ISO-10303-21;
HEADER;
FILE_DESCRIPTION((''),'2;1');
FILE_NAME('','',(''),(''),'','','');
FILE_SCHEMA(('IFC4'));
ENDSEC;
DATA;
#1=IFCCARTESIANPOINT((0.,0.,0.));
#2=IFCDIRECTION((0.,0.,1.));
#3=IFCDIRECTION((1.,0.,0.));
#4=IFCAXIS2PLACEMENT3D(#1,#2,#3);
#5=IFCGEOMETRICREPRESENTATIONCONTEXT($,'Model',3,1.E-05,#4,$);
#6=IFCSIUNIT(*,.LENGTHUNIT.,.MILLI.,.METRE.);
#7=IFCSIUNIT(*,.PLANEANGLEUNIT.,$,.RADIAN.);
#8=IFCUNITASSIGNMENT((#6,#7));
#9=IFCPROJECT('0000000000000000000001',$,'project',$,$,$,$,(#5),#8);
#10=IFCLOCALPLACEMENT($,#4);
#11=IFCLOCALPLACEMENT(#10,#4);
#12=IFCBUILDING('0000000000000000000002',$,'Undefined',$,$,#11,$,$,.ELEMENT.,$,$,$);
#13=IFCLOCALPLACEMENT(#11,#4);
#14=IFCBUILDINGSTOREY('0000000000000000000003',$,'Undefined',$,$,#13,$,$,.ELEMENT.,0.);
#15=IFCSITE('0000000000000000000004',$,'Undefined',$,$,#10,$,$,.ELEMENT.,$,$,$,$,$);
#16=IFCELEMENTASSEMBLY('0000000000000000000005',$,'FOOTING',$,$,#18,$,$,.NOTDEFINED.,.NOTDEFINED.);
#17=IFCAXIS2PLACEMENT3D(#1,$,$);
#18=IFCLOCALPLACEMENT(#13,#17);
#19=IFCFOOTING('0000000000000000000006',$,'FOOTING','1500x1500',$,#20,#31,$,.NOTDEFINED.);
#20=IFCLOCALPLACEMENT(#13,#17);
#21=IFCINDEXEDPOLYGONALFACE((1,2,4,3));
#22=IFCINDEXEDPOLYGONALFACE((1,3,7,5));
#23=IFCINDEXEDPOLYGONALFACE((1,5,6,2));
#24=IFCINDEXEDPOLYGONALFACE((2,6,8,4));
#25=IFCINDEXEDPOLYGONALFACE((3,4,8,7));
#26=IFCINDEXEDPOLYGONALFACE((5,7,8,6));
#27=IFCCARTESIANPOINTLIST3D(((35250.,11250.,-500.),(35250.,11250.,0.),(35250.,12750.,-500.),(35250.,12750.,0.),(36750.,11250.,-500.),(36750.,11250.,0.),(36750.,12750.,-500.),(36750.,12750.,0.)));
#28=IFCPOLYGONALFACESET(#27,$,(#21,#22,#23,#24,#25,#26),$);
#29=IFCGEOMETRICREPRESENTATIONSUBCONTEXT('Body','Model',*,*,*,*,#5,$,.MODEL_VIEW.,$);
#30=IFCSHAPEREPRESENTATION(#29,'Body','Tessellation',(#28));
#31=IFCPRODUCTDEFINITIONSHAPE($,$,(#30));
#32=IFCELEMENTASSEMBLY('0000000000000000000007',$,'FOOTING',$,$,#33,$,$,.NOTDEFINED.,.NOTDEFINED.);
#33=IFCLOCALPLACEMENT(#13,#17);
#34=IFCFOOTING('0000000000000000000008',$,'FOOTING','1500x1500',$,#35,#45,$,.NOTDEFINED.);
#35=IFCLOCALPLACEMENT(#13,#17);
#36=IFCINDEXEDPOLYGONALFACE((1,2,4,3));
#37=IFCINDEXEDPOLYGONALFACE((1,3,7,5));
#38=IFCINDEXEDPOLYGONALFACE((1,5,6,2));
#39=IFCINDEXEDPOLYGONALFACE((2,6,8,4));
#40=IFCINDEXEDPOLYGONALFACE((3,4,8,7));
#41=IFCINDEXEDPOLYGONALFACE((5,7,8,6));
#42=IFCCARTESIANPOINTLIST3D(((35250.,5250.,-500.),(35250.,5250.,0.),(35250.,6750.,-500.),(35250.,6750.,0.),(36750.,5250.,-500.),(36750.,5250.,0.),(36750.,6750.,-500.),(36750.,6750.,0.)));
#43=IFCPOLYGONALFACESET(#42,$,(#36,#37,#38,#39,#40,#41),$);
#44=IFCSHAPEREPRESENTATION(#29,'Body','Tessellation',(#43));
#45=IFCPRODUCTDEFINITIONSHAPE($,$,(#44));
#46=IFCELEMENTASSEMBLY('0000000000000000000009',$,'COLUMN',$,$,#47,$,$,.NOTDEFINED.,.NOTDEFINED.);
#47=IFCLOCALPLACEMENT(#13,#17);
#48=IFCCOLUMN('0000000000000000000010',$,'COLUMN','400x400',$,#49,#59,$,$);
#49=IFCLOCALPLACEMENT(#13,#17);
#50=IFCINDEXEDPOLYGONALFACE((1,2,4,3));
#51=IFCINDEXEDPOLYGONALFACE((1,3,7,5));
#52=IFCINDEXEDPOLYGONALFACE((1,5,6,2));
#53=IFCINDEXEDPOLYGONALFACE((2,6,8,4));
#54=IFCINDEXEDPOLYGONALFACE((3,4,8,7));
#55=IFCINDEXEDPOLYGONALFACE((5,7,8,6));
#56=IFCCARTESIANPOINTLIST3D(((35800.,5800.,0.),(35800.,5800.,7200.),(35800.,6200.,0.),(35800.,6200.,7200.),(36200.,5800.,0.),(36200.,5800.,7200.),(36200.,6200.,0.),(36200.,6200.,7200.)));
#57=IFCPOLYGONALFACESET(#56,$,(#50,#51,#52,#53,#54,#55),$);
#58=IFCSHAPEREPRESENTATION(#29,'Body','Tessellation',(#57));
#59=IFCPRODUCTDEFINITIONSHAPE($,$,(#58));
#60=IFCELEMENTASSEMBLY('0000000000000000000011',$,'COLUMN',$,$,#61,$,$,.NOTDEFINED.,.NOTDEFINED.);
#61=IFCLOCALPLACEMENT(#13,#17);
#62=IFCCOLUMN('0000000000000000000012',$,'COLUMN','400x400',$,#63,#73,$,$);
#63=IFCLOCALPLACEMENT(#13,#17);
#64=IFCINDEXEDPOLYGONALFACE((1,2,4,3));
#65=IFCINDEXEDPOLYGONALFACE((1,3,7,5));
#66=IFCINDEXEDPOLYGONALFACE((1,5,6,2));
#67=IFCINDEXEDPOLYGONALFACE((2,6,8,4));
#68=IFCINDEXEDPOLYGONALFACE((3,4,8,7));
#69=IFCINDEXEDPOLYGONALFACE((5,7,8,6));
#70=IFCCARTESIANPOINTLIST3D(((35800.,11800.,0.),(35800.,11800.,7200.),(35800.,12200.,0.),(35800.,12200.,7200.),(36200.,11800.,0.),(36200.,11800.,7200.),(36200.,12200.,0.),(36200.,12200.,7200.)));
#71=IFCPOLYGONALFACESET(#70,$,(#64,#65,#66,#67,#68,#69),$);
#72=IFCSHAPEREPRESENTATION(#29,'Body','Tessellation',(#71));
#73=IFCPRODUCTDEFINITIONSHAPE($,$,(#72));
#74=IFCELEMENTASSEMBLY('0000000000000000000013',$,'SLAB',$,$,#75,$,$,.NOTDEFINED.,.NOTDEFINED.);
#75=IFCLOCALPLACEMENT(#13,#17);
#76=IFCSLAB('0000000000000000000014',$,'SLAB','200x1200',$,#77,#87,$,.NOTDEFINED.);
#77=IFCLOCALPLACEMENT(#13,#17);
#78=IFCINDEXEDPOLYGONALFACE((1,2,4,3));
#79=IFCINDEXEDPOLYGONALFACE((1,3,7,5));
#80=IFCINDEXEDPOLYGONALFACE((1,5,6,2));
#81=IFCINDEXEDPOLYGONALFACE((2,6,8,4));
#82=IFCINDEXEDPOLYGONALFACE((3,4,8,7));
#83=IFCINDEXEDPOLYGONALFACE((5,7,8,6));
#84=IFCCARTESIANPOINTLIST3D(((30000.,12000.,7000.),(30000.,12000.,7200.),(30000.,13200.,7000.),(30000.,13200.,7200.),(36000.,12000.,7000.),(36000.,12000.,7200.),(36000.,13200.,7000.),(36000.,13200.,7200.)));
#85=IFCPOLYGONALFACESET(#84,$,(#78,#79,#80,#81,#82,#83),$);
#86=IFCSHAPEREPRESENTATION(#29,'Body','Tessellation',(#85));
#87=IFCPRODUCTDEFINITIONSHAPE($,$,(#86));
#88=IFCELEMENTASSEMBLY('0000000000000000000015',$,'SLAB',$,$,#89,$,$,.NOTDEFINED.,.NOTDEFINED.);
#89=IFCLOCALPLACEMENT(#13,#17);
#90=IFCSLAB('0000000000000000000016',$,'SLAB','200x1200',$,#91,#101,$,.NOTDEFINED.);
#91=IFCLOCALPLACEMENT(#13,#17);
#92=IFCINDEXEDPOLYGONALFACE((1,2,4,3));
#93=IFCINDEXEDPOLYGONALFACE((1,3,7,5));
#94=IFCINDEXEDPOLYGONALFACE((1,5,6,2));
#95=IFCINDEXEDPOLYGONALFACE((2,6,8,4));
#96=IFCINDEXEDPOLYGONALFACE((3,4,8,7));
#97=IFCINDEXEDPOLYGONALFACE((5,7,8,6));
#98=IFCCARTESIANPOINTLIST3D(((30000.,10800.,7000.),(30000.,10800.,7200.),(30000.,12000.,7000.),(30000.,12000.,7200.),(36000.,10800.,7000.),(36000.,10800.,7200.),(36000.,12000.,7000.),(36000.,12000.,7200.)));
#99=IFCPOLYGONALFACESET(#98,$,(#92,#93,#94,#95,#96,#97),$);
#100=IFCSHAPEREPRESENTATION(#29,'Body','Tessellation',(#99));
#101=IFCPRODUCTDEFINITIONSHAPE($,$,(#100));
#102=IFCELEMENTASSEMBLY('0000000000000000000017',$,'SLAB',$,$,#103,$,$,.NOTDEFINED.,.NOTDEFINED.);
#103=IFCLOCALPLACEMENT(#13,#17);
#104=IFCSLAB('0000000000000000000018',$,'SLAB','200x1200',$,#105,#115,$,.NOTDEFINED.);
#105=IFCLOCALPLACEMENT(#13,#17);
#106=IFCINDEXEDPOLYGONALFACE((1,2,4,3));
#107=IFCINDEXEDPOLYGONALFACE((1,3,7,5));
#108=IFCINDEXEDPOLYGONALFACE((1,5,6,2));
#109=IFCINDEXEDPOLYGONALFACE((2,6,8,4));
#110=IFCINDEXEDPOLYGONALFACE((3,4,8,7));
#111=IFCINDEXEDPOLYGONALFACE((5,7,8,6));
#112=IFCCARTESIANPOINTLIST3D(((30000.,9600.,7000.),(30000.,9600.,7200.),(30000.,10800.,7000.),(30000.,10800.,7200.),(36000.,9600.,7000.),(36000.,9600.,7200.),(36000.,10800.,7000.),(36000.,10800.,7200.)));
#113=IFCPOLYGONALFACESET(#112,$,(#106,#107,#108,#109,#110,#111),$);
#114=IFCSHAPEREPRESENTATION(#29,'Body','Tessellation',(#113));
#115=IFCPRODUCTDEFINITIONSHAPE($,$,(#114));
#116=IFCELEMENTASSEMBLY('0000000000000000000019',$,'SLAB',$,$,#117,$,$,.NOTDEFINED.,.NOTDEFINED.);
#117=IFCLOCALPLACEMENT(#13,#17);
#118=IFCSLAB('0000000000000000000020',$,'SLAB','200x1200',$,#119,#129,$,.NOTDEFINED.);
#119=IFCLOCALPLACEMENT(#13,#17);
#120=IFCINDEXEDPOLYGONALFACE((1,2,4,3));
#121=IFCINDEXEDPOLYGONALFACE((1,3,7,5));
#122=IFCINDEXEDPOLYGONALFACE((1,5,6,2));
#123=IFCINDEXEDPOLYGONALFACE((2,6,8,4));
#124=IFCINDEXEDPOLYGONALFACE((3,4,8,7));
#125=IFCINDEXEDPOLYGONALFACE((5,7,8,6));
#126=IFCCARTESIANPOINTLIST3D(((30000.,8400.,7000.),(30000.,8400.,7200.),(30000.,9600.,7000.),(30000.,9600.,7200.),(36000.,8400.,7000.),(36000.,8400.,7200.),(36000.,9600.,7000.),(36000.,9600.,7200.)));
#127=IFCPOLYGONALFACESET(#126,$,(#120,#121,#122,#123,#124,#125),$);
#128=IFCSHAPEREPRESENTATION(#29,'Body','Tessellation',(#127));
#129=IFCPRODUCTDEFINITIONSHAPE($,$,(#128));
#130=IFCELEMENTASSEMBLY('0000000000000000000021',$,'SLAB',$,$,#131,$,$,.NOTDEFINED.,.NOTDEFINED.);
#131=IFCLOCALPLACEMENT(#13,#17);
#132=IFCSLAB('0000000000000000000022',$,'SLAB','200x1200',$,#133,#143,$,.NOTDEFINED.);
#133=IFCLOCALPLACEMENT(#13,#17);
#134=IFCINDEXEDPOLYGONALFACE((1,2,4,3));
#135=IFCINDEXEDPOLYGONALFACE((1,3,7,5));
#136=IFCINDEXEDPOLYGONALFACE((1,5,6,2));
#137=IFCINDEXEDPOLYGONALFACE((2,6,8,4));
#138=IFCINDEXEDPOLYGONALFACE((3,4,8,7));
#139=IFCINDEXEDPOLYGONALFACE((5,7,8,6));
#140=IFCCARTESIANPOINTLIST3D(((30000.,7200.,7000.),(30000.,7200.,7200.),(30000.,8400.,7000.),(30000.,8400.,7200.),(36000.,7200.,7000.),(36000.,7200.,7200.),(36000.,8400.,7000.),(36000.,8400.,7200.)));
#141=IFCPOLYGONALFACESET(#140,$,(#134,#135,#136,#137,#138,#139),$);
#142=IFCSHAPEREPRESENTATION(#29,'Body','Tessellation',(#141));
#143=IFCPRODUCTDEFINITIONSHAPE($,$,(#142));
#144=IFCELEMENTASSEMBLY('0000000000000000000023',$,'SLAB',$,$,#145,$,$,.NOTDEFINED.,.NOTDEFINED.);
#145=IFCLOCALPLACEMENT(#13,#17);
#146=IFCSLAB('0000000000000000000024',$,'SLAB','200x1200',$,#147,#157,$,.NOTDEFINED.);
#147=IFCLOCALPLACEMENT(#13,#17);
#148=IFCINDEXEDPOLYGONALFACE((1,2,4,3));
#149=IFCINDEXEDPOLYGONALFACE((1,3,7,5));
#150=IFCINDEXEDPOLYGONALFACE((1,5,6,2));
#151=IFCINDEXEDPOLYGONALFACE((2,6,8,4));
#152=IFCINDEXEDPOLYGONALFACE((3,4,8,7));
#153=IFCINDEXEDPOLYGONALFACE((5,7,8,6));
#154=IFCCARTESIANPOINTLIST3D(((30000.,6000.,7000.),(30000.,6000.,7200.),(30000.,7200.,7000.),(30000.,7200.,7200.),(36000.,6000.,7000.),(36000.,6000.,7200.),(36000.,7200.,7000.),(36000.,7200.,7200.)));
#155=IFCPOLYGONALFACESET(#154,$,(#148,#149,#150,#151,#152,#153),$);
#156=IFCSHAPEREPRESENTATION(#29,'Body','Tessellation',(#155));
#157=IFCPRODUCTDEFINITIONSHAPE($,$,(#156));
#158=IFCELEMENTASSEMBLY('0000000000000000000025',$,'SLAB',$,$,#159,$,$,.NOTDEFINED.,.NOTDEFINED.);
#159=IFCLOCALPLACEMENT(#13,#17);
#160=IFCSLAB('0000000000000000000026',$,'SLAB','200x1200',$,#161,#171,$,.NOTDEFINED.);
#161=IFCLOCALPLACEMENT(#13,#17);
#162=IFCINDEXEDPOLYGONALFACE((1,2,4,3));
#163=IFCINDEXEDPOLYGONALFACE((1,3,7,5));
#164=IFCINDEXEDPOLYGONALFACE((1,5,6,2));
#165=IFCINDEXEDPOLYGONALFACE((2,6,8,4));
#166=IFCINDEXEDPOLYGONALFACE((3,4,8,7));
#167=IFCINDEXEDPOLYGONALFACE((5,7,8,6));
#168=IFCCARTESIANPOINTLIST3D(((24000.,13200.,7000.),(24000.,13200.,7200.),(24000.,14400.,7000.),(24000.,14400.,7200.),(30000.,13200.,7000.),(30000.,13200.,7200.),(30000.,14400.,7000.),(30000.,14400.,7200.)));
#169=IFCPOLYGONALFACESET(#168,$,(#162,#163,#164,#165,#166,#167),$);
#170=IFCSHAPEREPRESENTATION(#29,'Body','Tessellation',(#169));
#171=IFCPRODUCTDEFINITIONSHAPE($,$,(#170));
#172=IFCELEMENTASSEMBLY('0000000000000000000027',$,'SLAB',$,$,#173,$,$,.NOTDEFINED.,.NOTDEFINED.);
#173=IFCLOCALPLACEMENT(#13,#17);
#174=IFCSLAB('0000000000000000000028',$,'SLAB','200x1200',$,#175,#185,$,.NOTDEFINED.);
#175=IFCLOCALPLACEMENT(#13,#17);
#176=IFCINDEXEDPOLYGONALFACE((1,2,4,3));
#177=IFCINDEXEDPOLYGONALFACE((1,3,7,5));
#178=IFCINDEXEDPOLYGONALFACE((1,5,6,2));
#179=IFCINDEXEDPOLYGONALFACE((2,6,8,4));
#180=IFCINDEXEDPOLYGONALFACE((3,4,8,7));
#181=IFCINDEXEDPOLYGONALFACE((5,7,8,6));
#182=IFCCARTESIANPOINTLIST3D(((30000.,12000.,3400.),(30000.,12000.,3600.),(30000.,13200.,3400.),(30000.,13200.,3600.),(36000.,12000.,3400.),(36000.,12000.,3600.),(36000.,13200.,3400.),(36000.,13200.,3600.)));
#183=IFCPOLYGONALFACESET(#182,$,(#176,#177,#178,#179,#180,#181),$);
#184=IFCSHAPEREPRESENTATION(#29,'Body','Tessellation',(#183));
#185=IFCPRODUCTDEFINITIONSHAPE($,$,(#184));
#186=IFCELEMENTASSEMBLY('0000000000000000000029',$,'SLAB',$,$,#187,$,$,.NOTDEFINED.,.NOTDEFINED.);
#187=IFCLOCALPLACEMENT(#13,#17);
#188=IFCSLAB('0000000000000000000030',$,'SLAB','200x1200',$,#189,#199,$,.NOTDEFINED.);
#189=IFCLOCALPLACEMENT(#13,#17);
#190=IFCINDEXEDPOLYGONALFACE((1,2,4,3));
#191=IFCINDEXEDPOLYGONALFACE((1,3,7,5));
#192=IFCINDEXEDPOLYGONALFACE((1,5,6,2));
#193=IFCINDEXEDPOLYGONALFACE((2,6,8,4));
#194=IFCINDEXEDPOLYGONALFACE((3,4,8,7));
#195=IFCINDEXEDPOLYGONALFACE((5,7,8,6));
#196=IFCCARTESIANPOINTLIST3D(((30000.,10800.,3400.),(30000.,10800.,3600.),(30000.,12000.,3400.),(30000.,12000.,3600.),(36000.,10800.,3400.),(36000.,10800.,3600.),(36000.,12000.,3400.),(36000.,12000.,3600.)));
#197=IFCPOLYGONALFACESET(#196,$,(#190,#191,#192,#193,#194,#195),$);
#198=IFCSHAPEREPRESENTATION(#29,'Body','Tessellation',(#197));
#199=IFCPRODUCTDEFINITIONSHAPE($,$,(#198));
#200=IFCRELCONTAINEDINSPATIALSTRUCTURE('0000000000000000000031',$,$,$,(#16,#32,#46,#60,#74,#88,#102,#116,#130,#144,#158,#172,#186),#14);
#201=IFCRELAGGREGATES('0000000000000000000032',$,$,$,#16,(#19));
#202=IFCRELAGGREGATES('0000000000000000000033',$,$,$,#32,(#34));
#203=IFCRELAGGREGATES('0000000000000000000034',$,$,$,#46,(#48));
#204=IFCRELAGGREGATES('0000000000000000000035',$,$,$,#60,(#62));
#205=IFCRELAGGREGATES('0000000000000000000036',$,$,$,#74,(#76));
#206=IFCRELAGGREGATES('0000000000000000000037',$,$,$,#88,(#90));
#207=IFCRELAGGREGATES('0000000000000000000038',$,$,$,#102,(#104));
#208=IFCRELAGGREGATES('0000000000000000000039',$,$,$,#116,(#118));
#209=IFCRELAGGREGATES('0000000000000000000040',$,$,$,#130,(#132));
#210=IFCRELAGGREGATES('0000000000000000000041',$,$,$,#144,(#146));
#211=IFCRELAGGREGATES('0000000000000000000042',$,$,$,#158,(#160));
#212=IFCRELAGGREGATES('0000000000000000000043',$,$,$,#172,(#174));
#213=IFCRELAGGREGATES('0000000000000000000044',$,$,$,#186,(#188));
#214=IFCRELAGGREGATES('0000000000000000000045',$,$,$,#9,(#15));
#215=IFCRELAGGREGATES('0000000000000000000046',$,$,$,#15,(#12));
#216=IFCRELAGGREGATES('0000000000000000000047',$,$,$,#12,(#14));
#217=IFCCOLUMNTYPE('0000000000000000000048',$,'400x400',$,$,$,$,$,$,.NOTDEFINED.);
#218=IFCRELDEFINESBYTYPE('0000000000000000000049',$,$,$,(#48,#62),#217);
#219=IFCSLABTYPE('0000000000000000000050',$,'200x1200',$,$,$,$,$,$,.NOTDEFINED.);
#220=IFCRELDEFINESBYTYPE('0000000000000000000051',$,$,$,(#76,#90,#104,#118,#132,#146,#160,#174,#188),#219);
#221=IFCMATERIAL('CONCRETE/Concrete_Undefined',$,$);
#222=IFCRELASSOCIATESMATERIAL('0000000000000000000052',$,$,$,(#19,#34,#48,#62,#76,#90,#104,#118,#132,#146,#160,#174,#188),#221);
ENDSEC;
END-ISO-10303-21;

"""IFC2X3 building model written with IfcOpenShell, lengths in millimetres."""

from ifc_helpers import new_model, si_unit, frame, origin_with_axes, origin_2d_with_axis, place, context, subcontext, project, spatial, polyline, rectangle, outline, extrude, material, type_object, element, aggregate, save


model = new_model("IFC2X3")

# Units and contexts
model_context = context("Model", 3, precision=1e-05, world=origin_with_axes())
body_context = subcontext(model_context, "Body", "Model", "MODEL_VIEW")
ifc_project = project(units=[si_unit("LENGTHUNIT", "METRE", prefix="MILLI"), si_unit("PLANEANGLEUNIT", "RADIAN")], contexts=[model_context])

# Site, building, storey
site_placement = place(None, origin_with_axes())
site = spatial("IfcSite", under=ifc_project, at=site_placement, Name="Undefined", CompositionType="ELEMENT")
building_placement = place(site_placement, origin_with_axes())
building = spatial("IfcBuilding", under=site, at=building_placement, Name="Undefined", CompositionType="ELEMENT")
storey_placement = place(building_placement, origin_with_axes())
storey = spatial("IfcBuildingStorey", under=building, at=storey_placement, Name="Undefined", CompositionType="ELEMENT", Elevation=0.0)

# Element assemblies, footings
assembly_1_placement = place(storey_placement, origin_with_axes())
assembly_1 = element("IfcElementAssembly", 1, at=assembly_1_placement, inside=storey, Name="FOOTING", AssemblyPlace="NOTDEFINED", PredefinedType="NOTDEFINED")
ifc_material = material(Name="CONCRETE/Concrete_Undefined")
footing_1_placement = place(assembly_1_placement, frame((36000.0, 12000.0, -500.0), z_axis=(0.0, 1.0, 0.0), x_axis=(0.0, 0.0, 1.0)))
footing_1 = element("IfcFooting", 2, at=footing_1_placement, material=ifc_material, Name="FOOTING", Description="1500x1500", PredefinedType="NOTDEFINED", context=body_context, shape_type="SweptSolid", body=[
    extrude(rectangle(XDim=1500.0, YDim=1500.0, at=origin_2d_with_axis()), frame((500.0, 0.0, 0.0), z_axis=(-1.0, 0.0, 0.0), x_axis=(0.0, -1.0, 0.0)), (0.0, 0.0, 1.0), 500.0),
])
aggregate(assembly_1, [footing_1])
assembly_2_placement = place(storey_placement, origin_with_axes())
assembly_2 = element("IfcElementAssembly", 3, at=assembly_2_placement, inside=storey, Name="FOOTING", AssemblyPlace="NOTDEFINED", PredefinedType="NOTDEFINED")
footing_2_placement = place(assembly_2_placement, frame((36000.0, 6000.0, -500.0), z_axis=(0.0, 1.0, 0.0), x_axis=(0.0, 0.0, 1.0)))
footing_2 = element("IfcFooting", 4, at=footing_2_placement, material=ifc_material, Name="FOOTING", Description="1500x1500", PredefinedType="NOTDEFINED", context=body_context, shape_type="SweptSolid", body=[
    extrude(rectangle(XDim=1500.0, YDim=1500.0, at=origin_2d_with_axis()), frame((500.0, 0.0, 0.0), z_axis=(-1.0, 0.0, 0.0), x_axis=(0.0, -1.0, 0.0)), (0.0, 0.0, 1.0), 500.0),
])
aggregate(assembly_2, [footing_2])

# Element assemblies, columns
assembly_3_placement = place(storey_placement, origin_with_axes())
assembly_3 = element("IfcElementAssembly", 5, at=assembly_3_placement, inside=storey, Name="COLUMN", AssemblyPlace="NOTDEFINED", PredefinedType="NOTDEFINED")
column_type = type_object("IfcColumnType", Name="400x400", PredefinedType="NOTDEFINED")
column_1_placement = place(assembly_3_placement, frame((36000.0, 6000.0, 0.0), z_axis=(0.0, 0.0, 1.0), x_axis=(0.0, 1.0, 0.0)))
column_1 = element("IfcColumn", 6, at=column_1_placement, type_object=column_type, material=ifc_material, Name="COLUMN", Description="400x400", context=body_context, shape_type="SweptSolid", body=[
    extrude(rectangle(XDim=400.0, YDim=400.0, at=origin_2d_with_axis()), frame((0.0, 0.0, 7200.0), z_axis=(0.0, 0.0, -1.0), x_axis=(0.0, 1.0, 0.0)), (0.0, 0.0, 1.0), 7200.0),
])
aggregate(assembly_3, [column_1])
assembly_4_placement = place(storey_placement, origin_with_axes())
assembly_4 = element("IfcElementAssembly", 7, at=assembly_4_placement, inside=storey, Name="COLUMN", AssemblyPlace="NOTDEFINED", PredefinedType="NOTDEFINED")
column_2_placement = place(assembly_4_placement, frame((36000.0, 12000.0, 0.0), z_axis=(0.0, 0.0, 1.0), x_axis=(0.0, 1.0, 0.0)))
column_2 = element("IfcColumn", 8, at=column_2_placement, type_object=column_type, material=ifc_material, Name="COLUMN", Description="400x400", context=body_context, shape_type="SweptSolid", body=[
    extrude(rectangle(XDim=400.0, YDim=400.0, at=origin_2d_with_axis()), frame((0.0, 0.0, 7200.0), z_axis=(0.0, 0.0, -1.0), x_axis=(0.0, 1.0, 0.0)), (0.0, 0.0, 1.0), 7200.0),
])
aggregate(assembly_4, [column_2])

# Element assemblies, slabs
assembly_5_placement = place(storey_placement, origin_with_axes())
assembly_5 = element("IfcElementAssembly", 9, at=assembly_5_placement, inside=storey, Name="SLAB", AssemblyPlace="NOTDEFINED", PredefinedType="NOTDEFINED")
slab_type = type_object("IfcSlabType", Name="200x1200", PredefinedType="NOTDEFINED")
slab_1_placement = place(assembly_5_placement, frame((36000.0, 12000.0, 7100.0), z_axis=(0.0, 0.0, 1.0), x_axis=(0.0, 1.0, 0.0)))
slab_1 = element("IfcSlab", 10, at=slab_1_placement, type_object=slab_type, material=ifc_material, Name="SLAB", Description="200x1200", PredefinedType="NOTDEFINED", context=body_context, shape_type="SweptSolid", body=[
    extrude(outline(polyline([(0.0, 0.0), (1200.0, 0.0), (1200.0, 6000.0), (0.0, 6000.0), (0.0, 0.0)])), frame((0.0, 0.0, -100.0), z_axis=(0.0, 0.0, 1.0), x_axis=(1.0, 0.0, 0.0)), (0.0, 0.0, 1.0), 200.0),
])
aggregate(assembly_5, [slab_1])
assembly_6_placement = place(storey_placement, origin_with_axes())
assembly_6 = element("IfcElementAssembly", 11, at=assembly_6_placement, inside=storey, Name="SLAB", AssemblyPlace="NOTDEFINED", PredefinedType="NOTDEFINED")
slab_2_placement = place(assembly_6_placement, frame((36000.0, 10800.0, 7100.0), z_axis=(0.0, 0.0, 1.0), x_axis=(0.0, 1.0, 0.0)))
slab_2 = element("IfcSlab", 12, at=slab_2_placement, type_object=slab_type, material=ifc_material, Name="SLAB", Description="200x1200", PredefinedType="NOTDEFINED", context=body_context, shape_type="SweptSolid", body=[
    extrude(outline(polyline([(0.0, 0.0), (1200.0, 0.0), (1200.0, 6000.0), (0.0, 6000.0), (0.0, 0.0)])), frame((0.0, 0.0, -100.0), z_axis=(0.0, 0.0, 1.0), x_axis=(1.0, 0.0, 0.0)), (0.0, 0.0, 1.0), 200.0),
])
aggregate(assembly_6, [slab_2])
assembly_7_placement = place(storey_placement, origin_with_axes())
assembly_7 = element("IfcElementAssembly", 13, at=assembly_7_placement, inside=storey, Name="SLAB", AssemblyPlace="NOTDEFINED", PredefinedType="NOTDEFINED")
slab_3_placement = place(assembly_7_placement, frame((36000.0, 9600.0, 7100.0), z_axis=(0.0, 0.0, 1.0), x_axis=(0.0, 1.0, 0.0)))
slab_3 = element("IfcSlab", 14, at=slab_3_placement, type_object=slab_type, material=ifc_material, Name="SLAB", Description="200x1200", PredefinedType="NOTDEFINED", context=body_context, shape_type="SweptSolid", body=[
    extrude(outline(polyline([(0.0, 0.0), (1200.0, 0.0), (1200.0, 6000.0), (0.0, 6000.0), (0.0, 0.0)])), frame((0.0, 0.0, -100.0), z_axis=(0.0, 0.0, 1.0), x_axis=(1.0, 0.0, 0.0)), (0.0, 0.0, 1.0), 200.0),
])
aggregate(assembly_7, [slab_3])
assembly_8_placement = place(storey_placement, origin_with_axes())
assembly_8 = element("IfcElementAssembly", 15, at=assembly_8_placement, inside=storey, Name="SLAB", AssemblyPlace="NOTDEFINED", PredefinedType="NOTDEFINED")
slab_4_placement = place(assembly_8_placement, frame((36000.0, 8400.0, 7100.0), z_axis=(0.0, 0.0, 1.0), x_axis=(0.0, 1.0, 0.0)))
slab_4 = element("IfcSlab", 16, at=slab_4_placement, type_object=slab_type, material=ifc_material, Name="SLAB", Description="200x1200", PredefinedType="NOTDEFINED", context=body_context, shape_type="SweptSolid", body=[
    extrude(outline(polyline([(0.0, 0.0), (1200.0, 0.0), (1200.0, 6000.0), (0.0, 6000.0), (0.0, 0.0)])), frame((0.0, 0.0, -100.0), z_axis=(0.0, 0.0, 1.0), x_axis=(1.0, 0.0, 0.0)), (0.0, 0.0, 1.0), 200.0),
])
aggregate(assembly_8, [slab_4])
assembly_9_placement = place(storey_placement, origin_with_axes())
assembly_9 = element("IfcElementAssembly", 17, at=assembly_9_placement, inside=storey, Name="SLAB", AssemblyPlace="NOTDEFINED", PredefinedType="NOTDEFINED")
slab_5_placement = place(assembly_9_placement, frame((36000.0, 7200.0, 7100.0), z_axis=(0.0, 0.0, 1.0), x_axis=(0.0, 1.0, 0.0)))
slab_5 = element("IfcSlab", 18, at=slab_5_placement, type_object=slab_type, material=ifc_material, Name="SLAB", Description="200x1200", PredefinedType="NOTDEFINED", context=body_context, shape_type="SweptSolid", body=[
    extrude(outline(polyline([(0.0, 0.0), (1200.0, 0.0), (1200.0, 6000.0), (0.0, 6000.0), (0.0, 0.0)])), frame((0.0, 0.0, -100.0), z_axis=(0.0, 0.0, 1.0), x_axis=(1.0, 0.0, 0.0)), (0.0, 0.0, 1.0), 200.0),
])
aggregate(assembly_9, [slab_5])
assembly_10_placement = place(storey_placement, origin_with_axes())
assembly_10 = element("IfcElementAssembly", 19, at=assembly_10_placement, inside=storey, Name="SLAB", AssemblyPlace="NOTDEFINED", PredefinedType="NOTDEFINED")
slab_6_placement = place(assembly_10_placement, frame((36000.0, 6000.0, 7100.0), z_axis=(0.0, 0.0, 1.0), x_axis=(0.0, 1.0, 0.0)))
slab_6 = element("IfcSlab", 20, at=slab_6_placement, type_object=slab_type, material=ifc_material, Name="SLAB", Description="200x1200", PredefinedType="NOTDEFINED", context=body_context, shape_type="SweptSolid", body=[
    extrude(outline(polyline([(0.0, 0.0), (1200.0, 0.0), (1200.0, 6000.0), (0.0, 6000.0), (0.0, 0.0)])), frame((0.0, 0.0, -100.0), z_axis=(0.0, 0.0, 1.0), x_axis=(1.0, 0.0, 0.0)), (0.0, 0.0, 1.0), 200.0),
])
aggregate(assembly_10, [slab_6])
assembly_11_placement = place(storey_placement, origin_with_axes())
assembly_11 = element("IfcElementAssembly", 21, at=assembly_11_placement, inside=storey, Name="SLAB", AssemblyPlace="NOTDEFINED", PredefinedType="NOTDEFINED")
slab_7_placement = place(assembly_11_placement, frame((30000.0, 13200.0, 7100.0), z_axis=(0.0, 0.0, 1.0), x_axis=(0.0, 1.0, 0.0)))
slab_7 = element("IfcSlab", 22, at=slab_7_placement, type_object=slab_type, material=ifc_material, Name="SLAB", Description="200x1200", PredefinedType="NOTDEFINED", context=body_context, shape_type="SweptSolid", body=[
    extrude(outline(polyline([(0.0, 0.0), (1200.0, 0.0), (1200.0, 6000.0), (0.0, 6000.0), (0.0, 0.0)])), frame((0.0, 0.0, -100.0), z_axis=(0.0, 0.0, 1.0), x_axis=(1.0, 0.0, 0.0)), (0.0, 0.0, 1.0), 200.0),
])
aggregate(assembly_11, [slab_7])
assembly_12_placement = place(storey_placement, origin_with_axes())
assembly_12 = element("IfcElementAssembly", 23, at=assembly_12_placement, inside=storey, Name="SLAB", AssemblyPlace="NOTDEFINED", PredefinedType="NOTDEFINED")
slab_8_placement = place(assembly_12_placement, frame((36000.0, 12000.0, 3500.0), z_axis=(0.0, 0.0, 1.0), x_axis=(0.0, 1.0, 0.0)))
slab_8 = element("IfcSlab", 24, at=slab_8_placement, type_object=slab_type, material=ifc_material, Name="SLAB", Description="200x1200", PredefinedType="NOTDEFINED", context=body_context, shape_type="SweptSolid", body=[
    extrude(outline(polyline([(0.0, 0.0), (1200.0, 0.0), (1200.0, 6000.0), (0.0, 6000.0), (0.0, 0.0)])), frame((0.0, 0.0, -100.0), z_axis=(0.0, 0.0, 1.0), x_axis=(1.0, 0.0, 0.0)), (0.0, 0.0, 1.0), 200.0),
])
aggregate(assembly_12, [slab_8])
assembly_13_placement = place(storey_placement, origin_with_axes())
assembly_13 = element("IfcElementAssembly", 25, at=assembly_13_placement, inside=storey, Name="SLAB", AssemblyPlace="NOTDEFINED", PredefinedType="NOTDEFINED")
slab_9_placement = place(assembly_13_placement, frame((36000.0, 10800.0, 3500.0), z_axis=(0.0, 0.0, 1.0), x_axis=(0.0, 1.0, 0.0)))
slab_9 = element("IfcSlab", 26, at=slab_9_placement, type_object=slab_type, material=ifc_material, Name="SLAB", Description="200x1200", PredefinedType="NOTDEFINED", context=body_context, shape_type="SweptSolid", body=[
    extrude(outline(polyline([(0.0, 0.0), (1200.0, 0.0), (1200.0, 6000.0), (0.0, 6000.0), (0.0, 0.0)])), frame((0.0, 0.0, -100.0), z_axis=(0.0, 0.0, 1.0), x_axis=(1.0, 0.0, 0.0)), (0.0, 0.0, 1.0), 200.0),
])
aggregate(assembly_13, [slab_9])

save(model, "model.ifc")
